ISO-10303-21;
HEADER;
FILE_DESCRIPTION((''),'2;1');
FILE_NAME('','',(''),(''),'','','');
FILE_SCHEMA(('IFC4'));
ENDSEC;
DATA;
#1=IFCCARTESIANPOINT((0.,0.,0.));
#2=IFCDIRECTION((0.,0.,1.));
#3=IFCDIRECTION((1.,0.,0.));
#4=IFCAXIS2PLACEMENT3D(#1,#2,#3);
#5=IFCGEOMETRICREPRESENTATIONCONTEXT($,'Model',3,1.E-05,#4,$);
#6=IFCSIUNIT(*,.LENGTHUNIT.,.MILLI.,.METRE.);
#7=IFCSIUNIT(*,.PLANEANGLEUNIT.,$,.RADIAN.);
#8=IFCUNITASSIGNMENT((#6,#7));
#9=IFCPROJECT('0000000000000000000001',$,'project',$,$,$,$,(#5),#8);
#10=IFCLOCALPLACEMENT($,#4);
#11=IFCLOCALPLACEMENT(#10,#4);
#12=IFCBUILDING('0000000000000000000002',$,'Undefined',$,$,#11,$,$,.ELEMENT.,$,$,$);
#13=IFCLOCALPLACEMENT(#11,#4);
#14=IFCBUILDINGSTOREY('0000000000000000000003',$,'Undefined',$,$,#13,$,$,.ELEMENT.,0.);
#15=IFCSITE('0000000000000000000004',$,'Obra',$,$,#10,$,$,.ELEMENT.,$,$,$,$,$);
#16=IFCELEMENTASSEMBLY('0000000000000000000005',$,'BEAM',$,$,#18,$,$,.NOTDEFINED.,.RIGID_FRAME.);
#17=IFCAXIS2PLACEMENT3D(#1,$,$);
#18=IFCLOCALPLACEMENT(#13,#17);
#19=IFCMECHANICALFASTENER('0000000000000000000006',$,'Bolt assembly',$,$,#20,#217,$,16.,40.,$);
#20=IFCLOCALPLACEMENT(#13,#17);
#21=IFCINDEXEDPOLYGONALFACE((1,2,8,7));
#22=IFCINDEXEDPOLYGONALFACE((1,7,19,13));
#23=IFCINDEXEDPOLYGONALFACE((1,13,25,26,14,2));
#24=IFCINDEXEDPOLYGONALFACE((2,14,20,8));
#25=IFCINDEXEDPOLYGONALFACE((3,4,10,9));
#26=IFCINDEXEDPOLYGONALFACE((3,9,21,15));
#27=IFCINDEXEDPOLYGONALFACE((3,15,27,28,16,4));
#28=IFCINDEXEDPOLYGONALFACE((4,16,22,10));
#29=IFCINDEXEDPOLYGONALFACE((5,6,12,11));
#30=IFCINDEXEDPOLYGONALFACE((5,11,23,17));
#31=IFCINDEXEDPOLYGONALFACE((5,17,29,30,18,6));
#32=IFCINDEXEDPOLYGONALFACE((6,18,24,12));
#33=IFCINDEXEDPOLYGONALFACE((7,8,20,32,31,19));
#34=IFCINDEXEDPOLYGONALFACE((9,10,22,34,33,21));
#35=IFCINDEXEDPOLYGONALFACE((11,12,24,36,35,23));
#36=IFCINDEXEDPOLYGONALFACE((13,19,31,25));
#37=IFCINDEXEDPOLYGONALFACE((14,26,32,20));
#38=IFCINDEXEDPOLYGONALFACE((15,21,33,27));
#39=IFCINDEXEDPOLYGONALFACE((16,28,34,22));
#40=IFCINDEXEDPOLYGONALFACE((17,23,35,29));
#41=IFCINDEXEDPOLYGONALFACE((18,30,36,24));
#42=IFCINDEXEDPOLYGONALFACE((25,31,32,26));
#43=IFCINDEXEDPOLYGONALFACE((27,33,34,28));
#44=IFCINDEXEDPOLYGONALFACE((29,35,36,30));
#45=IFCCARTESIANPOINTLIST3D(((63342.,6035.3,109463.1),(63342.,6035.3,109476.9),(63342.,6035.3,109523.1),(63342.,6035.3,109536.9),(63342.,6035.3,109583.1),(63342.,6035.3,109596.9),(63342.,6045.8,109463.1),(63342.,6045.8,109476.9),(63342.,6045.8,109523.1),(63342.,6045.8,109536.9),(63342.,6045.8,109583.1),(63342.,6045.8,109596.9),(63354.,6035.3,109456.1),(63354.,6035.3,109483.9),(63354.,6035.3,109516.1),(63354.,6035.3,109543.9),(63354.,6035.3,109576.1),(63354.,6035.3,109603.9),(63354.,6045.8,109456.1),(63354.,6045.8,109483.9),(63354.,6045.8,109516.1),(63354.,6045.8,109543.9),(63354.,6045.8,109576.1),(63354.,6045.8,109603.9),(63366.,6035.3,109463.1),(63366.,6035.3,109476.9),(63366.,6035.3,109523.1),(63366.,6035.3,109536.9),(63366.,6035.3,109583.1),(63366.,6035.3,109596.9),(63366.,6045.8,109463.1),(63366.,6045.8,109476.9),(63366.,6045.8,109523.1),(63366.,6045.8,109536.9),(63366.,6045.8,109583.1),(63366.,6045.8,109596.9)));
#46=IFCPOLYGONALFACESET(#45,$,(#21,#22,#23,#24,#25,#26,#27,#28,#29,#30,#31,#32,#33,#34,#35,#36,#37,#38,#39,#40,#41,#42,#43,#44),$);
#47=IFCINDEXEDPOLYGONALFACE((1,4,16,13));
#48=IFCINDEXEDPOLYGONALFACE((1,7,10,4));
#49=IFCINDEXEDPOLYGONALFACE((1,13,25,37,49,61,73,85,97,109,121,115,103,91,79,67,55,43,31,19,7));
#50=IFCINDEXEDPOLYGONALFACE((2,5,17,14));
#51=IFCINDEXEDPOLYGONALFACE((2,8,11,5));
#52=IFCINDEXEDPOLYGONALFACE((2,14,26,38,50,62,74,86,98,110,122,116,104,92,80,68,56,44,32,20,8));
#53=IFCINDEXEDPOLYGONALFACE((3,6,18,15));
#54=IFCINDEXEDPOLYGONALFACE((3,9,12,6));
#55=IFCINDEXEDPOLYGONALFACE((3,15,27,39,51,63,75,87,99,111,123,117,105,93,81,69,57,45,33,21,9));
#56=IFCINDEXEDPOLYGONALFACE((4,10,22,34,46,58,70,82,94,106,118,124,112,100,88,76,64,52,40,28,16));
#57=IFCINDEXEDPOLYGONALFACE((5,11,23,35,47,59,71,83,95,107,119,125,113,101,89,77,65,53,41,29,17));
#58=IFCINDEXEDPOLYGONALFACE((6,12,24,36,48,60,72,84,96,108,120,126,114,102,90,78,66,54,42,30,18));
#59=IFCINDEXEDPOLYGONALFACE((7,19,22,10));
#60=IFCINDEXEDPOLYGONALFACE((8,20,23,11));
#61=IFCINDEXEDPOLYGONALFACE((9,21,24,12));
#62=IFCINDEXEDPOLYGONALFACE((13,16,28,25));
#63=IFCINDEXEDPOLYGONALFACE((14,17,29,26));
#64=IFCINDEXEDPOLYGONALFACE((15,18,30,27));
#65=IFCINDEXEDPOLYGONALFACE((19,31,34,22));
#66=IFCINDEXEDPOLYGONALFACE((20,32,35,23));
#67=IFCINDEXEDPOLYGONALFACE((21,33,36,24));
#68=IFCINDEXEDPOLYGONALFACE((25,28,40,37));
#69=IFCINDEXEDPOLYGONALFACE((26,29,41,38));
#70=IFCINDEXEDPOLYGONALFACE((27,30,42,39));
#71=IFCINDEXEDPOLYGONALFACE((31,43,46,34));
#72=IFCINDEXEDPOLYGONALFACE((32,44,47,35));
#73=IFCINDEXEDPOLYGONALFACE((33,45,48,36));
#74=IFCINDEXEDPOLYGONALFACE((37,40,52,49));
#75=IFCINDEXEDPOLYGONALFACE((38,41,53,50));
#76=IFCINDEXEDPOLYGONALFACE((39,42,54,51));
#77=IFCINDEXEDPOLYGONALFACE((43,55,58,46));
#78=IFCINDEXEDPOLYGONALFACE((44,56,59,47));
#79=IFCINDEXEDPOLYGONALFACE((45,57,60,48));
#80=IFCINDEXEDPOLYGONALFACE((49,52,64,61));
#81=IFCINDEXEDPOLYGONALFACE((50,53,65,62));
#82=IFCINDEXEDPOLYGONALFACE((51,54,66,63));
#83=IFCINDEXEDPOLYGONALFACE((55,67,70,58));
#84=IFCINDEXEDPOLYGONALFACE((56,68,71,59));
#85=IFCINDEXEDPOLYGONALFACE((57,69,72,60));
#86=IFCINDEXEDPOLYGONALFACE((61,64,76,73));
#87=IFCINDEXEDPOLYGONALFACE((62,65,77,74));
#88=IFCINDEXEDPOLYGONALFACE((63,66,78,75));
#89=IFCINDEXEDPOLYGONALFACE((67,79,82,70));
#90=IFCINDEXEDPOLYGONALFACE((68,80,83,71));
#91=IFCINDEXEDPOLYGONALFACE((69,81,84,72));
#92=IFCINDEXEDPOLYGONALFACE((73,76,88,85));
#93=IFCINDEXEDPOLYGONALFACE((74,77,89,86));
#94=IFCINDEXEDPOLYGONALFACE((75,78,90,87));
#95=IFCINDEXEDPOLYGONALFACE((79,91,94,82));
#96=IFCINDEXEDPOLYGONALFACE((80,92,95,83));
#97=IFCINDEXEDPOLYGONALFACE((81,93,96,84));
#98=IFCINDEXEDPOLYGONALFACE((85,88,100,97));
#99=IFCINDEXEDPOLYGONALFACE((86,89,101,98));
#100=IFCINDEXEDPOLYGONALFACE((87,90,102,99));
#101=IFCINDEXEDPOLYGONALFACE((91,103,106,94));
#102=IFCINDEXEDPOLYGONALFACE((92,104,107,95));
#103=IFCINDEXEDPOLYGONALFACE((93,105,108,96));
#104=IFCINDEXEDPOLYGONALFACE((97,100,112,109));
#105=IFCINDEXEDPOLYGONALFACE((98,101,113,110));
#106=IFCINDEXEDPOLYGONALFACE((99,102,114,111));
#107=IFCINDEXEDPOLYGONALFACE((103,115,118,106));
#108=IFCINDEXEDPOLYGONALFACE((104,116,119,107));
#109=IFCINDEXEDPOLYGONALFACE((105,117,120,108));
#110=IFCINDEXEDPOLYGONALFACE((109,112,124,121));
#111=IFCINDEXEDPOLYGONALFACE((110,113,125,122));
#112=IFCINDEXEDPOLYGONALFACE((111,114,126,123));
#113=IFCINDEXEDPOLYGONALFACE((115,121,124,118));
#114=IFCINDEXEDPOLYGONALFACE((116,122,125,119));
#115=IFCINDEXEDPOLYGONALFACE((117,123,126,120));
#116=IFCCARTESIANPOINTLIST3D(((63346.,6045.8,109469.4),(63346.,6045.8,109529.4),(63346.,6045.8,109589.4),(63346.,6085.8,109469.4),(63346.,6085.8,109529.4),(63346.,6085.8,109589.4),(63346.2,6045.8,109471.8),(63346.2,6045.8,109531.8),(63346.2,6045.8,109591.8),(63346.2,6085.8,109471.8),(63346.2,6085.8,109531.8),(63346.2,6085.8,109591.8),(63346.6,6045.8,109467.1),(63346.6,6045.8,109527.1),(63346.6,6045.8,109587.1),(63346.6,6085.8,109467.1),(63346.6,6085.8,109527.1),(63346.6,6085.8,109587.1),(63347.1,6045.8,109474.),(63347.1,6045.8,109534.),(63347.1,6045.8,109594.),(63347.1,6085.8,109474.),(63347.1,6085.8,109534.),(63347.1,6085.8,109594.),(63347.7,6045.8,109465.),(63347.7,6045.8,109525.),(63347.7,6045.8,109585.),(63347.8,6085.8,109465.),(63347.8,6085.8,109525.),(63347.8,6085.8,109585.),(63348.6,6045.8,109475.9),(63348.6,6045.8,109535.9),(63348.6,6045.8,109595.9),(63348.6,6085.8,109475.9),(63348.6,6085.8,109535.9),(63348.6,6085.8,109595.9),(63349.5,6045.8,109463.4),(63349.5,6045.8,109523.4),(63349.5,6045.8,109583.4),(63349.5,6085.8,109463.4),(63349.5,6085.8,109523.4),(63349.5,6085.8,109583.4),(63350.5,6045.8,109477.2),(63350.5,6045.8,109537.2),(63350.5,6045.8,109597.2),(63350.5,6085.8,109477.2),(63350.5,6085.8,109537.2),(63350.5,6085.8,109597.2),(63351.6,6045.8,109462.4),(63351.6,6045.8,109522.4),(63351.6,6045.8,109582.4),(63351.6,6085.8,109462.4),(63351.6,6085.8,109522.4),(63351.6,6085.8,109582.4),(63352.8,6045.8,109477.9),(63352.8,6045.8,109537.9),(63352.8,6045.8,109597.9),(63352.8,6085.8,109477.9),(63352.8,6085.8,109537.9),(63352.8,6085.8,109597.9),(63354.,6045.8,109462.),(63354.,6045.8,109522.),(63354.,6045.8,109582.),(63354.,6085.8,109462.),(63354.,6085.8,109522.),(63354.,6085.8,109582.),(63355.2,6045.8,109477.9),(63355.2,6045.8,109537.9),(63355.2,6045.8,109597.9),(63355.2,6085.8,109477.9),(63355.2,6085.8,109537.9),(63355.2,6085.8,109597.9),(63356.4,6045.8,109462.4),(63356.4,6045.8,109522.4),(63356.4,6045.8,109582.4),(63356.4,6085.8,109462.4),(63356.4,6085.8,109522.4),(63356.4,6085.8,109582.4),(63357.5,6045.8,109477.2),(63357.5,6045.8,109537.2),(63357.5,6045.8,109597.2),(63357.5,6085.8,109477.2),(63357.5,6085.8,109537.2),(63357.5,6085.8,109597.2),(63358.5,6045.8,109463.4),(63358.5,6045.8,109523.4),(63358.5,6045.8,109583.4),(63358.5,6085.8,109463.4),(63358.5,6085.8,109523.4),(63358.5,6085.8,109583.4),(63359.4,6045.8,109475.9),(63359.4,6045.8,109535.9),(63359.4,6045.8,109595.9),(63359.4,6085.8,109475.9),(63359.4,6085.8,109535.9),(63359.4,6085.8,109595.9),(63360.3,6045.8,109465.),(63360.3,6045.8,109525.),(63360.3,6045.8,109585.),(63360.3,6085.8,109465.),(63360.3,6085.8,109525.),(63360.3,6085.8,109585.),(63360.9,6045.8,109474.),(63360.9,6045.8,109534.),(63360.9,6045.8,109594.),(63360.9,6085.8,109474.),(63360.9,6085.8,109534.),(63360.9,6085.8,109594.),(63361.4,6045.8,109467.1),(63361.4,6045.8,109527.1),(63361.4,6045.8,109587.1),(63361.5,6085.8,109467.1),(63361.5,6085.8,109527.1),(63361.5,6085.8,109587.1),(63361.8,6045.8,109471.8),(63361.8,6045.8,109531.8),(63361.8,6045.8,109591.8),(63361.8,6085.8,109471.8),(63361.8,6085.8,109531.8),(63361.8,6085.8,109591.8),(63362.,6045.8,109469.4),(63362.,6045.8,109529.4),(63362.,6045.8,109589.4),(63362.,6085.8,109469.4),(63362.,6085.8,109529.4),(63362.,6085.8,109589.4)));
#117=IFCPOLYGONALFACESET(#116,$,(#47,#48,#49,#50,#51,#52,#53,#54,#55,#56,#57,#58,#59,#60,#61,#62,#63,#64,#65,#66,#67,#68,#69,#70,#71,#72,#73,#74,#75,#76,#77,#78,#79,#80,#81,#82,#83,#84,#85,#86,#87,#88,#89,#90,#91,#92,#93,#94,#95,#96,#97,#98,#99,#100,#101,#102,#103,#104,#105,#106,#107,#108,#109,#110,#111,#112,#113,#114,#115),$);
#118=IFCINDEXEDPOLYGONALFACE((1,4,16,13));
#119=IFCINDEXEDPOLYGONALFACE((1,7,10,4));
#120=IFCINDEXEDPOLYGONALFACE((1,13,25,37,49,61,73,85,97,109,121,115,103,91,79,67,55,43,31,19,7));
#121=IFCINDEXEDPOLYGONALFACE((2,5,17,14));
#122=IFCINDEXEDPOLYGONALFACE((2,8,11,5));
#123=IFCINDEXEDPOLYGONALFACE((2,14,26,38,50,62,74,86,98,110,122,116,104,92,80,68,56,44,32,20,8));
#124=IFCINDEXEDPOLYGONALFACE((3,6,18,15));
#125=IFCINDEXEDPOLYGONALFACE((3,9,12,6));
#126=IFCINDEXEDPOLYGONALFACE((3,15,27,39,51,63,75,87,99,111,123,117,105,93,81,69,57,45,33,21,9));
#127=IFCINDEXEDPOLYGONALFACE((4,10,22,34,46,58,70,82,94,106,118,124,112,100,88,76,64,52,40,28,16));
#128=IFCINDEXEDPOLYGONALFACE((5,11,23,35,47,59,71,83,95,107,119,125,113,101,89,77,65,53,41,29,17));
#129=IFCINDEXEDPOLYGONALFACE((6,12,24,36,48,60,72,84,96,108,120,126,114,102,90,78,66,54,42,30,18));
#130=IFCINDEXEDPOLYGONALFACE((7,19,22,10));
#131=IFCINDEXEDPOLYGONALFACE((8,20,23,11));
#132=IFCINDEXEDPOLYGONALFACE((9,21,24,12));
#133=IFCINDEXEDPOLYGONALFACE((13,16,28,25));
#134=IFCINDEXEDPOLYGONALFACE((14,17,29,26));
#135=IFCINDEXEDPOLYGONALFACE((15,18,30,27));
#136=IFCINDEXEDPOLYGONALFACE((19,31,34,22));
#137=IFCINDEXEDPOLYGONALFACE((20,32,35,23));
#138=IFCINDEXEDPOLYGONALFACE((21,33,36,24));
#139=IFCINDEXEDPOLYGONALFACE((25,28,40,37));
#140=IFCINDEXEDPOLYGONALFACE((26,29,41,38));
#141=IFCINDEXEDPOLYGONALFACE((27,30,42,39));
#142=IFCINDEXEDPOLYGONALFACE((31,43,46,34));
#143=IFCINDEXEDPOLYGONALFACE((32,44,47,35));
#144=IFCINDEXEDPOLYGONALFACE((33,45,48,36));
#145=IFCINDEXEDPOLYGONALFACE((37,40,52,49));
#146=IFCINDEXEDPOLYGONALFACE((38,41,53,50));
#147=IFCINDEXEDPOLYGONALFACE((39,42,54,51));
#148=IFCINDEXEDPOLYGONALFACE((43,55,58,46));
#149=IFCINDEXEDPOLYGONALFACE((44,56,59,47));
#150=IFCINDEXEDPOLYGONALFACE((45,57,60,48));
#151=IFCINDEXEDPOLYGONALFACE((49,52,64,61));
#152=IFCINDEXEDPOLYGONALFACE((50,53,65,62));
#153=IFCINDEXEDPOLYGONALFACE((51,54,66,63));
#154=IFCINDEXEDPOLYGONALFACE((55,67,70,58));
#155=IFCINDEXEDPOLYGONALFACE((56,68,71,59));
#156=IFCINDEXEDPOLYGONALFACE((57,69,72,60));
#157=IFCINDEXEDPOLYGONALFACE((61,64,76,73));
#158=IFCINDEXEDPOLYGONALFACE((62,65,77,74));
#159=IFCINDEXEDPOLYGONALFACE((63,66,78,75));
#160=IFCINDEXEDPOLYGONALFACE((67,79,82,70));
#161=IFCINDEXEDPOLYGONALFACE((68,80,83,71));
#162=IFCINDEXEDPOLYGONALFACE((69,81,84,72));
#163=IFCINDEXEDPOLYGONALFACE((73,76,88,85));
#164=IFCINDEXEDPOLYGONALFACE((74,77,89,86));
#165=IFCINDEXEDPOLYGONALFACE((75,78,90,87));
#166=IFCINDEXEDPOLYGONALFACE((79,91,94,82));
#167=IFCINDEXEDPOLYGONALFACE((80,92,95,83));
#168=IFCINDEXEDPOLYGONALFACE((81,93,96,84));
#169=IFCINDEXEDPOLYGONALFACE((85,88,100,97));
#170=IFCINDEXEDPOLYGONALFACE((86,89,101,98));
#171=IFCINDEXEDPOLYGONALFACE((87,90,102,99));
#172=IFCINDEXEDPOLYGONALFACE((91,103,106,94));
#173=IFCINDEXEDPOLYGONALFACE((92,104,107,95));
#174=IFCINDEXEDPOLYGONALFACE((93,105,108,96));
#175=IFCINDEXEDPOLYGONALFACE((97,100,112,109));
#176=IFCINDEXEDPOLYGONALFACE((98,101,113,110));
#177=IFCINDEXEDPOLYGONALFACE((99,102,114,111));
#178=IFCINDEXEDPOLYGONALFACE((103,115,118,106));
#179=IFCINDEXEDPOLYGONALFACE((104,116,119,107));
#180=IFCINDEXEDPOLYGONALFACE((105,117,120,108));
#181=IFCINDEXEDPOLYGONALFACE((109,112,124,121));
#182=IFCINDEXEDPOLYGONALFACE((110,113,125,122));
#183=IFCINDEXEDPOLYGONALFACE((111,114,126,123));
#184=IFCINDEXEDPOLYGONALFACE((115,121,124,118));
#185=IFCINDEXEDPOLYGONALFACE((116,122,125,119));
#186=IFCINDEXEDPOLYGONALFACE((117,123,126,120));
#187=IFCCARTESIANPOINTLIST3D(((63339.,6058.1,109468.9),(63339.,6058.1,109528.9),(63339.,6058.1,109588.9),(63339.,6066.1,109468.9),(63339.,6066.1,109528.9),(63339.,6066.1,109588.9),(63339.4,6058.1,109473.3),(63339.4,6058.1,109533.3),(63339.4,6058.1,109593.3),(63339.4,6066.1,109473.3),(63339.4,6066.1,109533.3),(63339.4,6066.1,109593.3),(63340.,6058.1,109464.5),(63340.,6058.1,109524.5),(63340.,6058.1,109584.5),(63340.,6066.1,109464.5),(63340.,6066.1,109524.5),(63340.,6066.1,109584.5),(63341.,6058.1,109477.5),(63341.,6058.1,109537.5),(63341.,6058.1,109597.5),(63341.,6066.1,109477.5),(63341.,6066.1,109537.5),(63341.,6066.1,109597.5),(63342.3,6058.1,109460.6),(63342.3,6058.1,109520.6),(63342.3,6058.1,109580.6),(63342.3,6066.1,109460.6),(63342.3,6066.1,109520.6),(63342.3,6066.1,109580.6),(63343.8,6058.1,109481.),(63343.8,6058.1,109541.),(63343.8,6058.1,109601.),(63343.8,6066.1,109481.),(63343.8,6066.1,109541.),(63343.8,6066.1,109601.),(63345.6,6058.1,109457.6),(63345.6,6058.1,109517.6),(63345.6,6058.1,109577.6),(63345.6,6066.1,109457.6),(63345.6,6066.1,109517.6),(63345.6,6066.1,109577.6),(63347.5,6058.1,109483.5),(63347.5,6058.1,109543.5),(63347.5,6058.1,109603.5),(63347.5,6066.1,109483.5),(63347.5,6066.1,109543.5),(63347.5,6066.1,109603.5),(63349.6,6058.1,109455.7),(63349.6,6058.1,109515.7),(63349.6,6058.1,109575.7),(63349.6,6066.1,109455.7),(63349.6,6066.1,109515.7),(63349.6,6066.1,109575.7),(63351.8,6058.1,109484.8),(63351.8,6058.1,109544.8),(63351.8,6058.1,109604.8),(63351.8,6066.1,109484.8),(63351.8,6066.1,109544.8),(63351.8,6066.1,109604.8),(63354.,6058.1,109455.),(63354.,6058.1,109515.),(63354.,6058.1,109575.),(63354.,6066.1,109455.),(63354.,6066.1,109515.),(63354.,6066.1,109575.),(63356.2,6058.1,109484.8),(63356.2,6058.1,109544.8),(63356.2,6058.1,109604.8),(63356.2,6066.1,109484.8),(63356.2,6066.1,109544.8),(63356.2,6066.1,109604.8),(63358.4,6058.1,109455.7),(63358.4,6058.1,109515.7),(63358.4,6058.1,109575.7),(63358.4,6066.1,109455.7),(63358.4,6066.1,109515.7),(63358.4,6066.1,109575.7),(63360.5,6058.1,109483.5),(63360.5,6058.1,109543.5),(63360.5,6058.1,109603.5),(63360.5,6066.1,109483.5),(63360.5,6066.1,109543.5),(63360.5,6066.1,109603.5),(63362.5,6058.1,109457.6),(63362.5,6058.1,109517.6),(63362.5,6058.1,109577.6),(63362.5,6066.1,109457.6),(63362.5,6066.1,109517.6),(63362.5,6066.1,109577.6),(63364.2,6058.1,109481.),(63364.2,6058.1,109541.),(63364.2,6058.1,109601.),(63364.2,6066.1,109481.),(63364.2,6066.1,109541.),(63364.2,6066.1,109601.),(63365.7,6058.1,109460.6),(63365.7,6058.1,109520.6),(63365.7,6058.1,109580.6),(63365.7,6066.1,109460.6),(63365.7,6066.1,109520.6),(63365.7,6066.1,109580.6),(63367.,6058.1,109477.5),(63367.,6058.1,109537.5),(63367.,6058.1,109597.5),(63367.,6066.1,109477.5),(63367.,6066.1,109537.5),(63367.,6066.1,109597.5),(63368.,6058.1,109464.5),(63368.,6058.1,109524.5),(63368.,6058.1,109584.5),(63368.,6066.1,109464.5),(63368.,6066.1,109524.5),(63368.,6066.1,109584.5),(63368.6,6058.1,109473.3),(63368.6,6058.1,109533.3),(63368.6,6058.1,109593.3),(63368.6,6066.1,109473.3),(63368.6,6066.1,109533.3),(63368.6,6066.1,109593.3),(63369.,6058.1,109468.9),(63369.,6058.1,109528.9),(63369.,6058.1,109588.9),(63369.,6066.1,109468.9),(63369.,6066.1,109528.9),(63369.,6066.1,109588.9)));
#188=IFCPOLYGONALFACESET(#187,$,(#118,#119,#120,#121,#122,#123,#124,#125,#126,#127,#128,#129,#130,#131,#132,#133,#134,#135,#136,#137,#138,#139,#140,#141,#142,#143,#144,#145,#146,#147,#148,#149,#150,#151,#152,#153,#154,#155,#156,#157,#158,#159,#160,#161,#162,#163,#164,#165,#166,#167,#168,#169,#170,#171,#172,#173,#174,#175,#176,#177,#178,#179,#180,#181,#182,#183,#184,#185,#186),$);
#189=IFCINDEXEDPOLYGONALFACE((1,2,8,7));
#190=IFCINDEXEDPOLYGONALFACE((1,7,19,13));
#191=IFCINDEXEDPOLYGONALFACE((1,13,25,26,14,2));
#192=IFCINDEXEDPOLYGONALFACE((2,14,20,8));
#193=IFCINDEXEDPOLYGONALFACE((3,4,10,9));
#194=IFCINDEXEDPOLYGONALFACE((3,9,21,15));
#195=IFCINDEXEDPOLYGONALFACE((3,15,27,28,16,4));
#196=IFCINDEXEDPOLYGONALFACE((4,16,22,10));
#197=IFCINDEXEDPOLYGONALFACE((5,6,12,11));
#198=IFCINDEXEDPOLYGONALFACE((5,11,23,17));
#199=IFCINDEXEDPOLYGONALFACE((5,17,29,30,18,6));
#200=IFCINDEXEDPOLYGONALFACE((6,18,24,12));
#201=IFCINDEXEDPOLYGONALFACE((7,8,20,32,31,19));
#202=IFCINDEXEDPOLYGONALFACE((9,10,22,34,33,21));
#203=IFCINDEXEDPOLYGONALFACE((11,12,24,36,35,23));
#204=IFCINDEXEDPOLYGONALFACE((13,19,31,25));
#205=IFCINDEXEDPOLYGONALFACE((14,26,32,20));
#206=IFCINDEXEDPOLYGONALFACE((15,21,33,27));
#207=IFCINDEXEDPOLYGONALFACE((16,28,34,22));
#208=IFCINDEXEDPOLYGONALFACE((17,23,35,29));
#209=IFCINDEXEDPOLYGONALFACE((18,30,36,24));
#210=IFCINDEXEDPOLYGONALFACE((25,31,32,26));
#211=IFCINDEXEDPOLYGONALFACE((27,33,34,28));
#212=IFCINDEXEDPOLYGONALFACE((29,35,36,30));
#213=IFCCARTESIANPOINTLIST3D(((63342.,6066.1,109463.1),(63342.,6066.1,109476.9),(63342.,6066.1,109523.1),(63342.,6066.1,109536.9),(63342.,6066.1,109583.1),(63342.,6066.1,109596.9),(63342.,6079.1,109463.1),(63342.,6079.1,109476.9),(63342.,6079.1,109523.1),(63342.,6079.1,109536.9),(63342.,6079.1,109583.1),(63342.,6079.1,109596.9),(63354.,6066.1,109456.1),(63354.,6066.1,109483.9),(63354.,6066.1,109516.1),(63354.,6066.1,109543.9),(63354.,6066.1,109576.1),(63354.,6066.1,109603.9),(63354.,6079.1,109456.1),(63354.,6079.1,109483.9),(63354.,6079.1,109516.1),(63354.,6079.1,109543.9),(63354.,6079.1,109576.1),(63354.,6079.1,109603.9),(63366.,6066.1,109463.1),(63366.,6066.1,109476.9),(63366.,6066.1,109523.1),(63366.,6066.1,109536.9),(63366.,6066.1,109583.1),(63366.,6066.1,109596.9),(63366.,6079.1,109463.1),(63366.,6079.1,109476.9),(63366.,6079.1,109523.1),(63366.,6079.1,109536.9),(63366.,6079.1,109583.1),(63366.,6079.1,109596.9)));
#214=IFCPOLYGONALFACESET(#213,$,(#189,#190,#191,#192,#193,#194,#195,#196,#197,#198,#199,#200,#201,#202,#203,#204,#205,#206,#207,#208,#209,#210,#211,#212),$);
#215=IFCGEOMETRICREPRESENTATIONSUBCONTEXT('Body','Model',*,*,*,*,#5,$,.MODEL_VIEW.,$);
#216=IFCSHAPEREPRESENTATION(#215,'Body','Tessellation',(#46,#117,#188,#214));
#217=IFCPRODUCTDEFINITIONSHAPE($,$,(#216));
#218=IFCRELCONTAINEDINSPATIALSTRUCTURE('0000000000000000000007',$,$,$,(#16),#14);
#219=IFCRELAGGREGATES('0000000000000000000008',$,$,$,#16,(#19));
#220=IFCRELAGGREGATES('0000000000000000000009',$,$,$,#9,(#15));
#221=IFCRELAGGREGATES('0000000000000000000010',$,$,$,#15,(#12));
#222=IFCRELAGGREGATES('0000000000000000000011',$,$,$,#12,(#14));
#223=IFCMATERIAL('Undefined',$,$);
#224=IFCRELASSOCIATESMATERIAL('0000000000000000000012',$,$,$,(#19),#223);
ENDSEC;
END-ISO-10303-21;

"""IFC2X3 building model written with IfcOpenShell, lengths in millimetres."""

from ifc_helpers import new_model, si_unit, frame, origin_with_axes, origin_2d_with_axis, place, context, subcontext, project, spatial, polyline, circle, outline, extrude, source, transform, mapped, material, element, aggregate, save


model = new_model("IFC2X3")

# Units and contexts
model_context = context("Model", 3, precision=1e-05, world=origin_with_axes())
body_context = subcontext(model_context, "Body", "Model", "MODEL_VIEW")
ifc_project = project(units=[si_unit("LENGTHUNIT", "METRE", prefix="MILLI"), si_unit("PLANEANGLEUNIT", "RADIAN")], contexts=[model_context])

# Site, building, storey
site_placement = place(None, origin_with_axes())
site = spatial("IfcSite", under=ifc_project, at=site_placement, Name="Obra", CompositionType="ELEMENT")
building_placement = place(site_placement, origin_with_axes())
building = spatial("IfcBuilding", under=site, at=building_placement, Name="Undefined", CompositionType="ELEMENT")
storey_placement = place(building_placement, origin_with_axes())
storey = spatial("IfcBuildingStorey", under=building, at=storey_placement, Name="Undefined", CompositionType="ELEMENT", Elevation=0.0)

# Element assembly
assembly_1_placement = place(storey_placement, origin_with_axes())
assembly_1 = element("IfcElementAssembly", 1, at=assembly_1_placement, inside=storey, Name="BEAM", AssemblyPlace="NOTDEFINED", PredefinedType="RIGID_FRAME")

# Mechanical fastener
ifc_material_1 = material(Name="Undefined")
shared_shape_1 = source(origin_with_axes(), body_context, "Body", "SweptSolid", [
    extrude(outline(polyline([(13.9, 0.0), (6.9, 12.0), (-6.9, 12.0), (-13.9, 0.0), (-6.9, -12.0), (6.9, -12.0), (13.9, 0.0)])), frame((0.0, -19.7, 0.0), z_axis=(0.0, 1.0, 0.0), x_axis=(1.0, 0.0, 0.0)), (0.0, 0.0, 1.0), 10.6),
    extrude(circle(Radius=8.0, at=origin_2d_with_axis()), frame((0.0, -9.1, 0.0), z_axis=(0.0, 1.0, 0.0), x_axis=(1.0, 0.0, 0.0)), (0.0, 0.0, 1.0), 40.0),
    extrude(circle(Radius=15.0, at=origin_2d_with_axis()), frame((0.0, 3.1, 0.0), z_axis=(0.0, 1.0, 0.0), x_axis=(1.0, 0.0, 0.0)), (0.0, 0.0, 1.0), 8.0),
    extrude(outline(polyline([(13.9, 0.0), (6.9, 12.0), (-6.9, 12.0), (-13.9, 0.0), (-6.9, -12.0), (6.9, -12.0), (13.9, 0.0)])), frame((0.0, 11.1, 0.0), z_axis=(0.0, 1.0, 0.0), x_axis=(1.0, 0.0, 0.0)), (0.0, 0.0, 1.0), 13.0),
])
mechanical_fastener_1_placement = place(assembly_1_placement, frame((63304.0, 6055.0, 109650.0), z_axis=(1.0, -0.000126, 0.0), x_axis=(0.0, 0.0, -1.0)))
mechanical_fastener_1 = element("IfcMechanicalFastener", 2, at=mechanical_fastener_1_placement, material=ifc_material_1, Name="Bolt assembly", NominalDiameter=16.0, NominalLength=40.0, context=body_context, shape_type="MappedRepresentation", body=[
    mapped(shared_shape_1, transform((60.0, 0.0, 50.0))),
    mapped(shared_shape_1, transform((120.0, 0.0, 50.0))),
    mapped(shared_shape_1, transform((180.0, 0.0, 50.0))),
])
aggregate(assembly_1, [mechanical_fastener_1])

save(model, "model.ifc")
